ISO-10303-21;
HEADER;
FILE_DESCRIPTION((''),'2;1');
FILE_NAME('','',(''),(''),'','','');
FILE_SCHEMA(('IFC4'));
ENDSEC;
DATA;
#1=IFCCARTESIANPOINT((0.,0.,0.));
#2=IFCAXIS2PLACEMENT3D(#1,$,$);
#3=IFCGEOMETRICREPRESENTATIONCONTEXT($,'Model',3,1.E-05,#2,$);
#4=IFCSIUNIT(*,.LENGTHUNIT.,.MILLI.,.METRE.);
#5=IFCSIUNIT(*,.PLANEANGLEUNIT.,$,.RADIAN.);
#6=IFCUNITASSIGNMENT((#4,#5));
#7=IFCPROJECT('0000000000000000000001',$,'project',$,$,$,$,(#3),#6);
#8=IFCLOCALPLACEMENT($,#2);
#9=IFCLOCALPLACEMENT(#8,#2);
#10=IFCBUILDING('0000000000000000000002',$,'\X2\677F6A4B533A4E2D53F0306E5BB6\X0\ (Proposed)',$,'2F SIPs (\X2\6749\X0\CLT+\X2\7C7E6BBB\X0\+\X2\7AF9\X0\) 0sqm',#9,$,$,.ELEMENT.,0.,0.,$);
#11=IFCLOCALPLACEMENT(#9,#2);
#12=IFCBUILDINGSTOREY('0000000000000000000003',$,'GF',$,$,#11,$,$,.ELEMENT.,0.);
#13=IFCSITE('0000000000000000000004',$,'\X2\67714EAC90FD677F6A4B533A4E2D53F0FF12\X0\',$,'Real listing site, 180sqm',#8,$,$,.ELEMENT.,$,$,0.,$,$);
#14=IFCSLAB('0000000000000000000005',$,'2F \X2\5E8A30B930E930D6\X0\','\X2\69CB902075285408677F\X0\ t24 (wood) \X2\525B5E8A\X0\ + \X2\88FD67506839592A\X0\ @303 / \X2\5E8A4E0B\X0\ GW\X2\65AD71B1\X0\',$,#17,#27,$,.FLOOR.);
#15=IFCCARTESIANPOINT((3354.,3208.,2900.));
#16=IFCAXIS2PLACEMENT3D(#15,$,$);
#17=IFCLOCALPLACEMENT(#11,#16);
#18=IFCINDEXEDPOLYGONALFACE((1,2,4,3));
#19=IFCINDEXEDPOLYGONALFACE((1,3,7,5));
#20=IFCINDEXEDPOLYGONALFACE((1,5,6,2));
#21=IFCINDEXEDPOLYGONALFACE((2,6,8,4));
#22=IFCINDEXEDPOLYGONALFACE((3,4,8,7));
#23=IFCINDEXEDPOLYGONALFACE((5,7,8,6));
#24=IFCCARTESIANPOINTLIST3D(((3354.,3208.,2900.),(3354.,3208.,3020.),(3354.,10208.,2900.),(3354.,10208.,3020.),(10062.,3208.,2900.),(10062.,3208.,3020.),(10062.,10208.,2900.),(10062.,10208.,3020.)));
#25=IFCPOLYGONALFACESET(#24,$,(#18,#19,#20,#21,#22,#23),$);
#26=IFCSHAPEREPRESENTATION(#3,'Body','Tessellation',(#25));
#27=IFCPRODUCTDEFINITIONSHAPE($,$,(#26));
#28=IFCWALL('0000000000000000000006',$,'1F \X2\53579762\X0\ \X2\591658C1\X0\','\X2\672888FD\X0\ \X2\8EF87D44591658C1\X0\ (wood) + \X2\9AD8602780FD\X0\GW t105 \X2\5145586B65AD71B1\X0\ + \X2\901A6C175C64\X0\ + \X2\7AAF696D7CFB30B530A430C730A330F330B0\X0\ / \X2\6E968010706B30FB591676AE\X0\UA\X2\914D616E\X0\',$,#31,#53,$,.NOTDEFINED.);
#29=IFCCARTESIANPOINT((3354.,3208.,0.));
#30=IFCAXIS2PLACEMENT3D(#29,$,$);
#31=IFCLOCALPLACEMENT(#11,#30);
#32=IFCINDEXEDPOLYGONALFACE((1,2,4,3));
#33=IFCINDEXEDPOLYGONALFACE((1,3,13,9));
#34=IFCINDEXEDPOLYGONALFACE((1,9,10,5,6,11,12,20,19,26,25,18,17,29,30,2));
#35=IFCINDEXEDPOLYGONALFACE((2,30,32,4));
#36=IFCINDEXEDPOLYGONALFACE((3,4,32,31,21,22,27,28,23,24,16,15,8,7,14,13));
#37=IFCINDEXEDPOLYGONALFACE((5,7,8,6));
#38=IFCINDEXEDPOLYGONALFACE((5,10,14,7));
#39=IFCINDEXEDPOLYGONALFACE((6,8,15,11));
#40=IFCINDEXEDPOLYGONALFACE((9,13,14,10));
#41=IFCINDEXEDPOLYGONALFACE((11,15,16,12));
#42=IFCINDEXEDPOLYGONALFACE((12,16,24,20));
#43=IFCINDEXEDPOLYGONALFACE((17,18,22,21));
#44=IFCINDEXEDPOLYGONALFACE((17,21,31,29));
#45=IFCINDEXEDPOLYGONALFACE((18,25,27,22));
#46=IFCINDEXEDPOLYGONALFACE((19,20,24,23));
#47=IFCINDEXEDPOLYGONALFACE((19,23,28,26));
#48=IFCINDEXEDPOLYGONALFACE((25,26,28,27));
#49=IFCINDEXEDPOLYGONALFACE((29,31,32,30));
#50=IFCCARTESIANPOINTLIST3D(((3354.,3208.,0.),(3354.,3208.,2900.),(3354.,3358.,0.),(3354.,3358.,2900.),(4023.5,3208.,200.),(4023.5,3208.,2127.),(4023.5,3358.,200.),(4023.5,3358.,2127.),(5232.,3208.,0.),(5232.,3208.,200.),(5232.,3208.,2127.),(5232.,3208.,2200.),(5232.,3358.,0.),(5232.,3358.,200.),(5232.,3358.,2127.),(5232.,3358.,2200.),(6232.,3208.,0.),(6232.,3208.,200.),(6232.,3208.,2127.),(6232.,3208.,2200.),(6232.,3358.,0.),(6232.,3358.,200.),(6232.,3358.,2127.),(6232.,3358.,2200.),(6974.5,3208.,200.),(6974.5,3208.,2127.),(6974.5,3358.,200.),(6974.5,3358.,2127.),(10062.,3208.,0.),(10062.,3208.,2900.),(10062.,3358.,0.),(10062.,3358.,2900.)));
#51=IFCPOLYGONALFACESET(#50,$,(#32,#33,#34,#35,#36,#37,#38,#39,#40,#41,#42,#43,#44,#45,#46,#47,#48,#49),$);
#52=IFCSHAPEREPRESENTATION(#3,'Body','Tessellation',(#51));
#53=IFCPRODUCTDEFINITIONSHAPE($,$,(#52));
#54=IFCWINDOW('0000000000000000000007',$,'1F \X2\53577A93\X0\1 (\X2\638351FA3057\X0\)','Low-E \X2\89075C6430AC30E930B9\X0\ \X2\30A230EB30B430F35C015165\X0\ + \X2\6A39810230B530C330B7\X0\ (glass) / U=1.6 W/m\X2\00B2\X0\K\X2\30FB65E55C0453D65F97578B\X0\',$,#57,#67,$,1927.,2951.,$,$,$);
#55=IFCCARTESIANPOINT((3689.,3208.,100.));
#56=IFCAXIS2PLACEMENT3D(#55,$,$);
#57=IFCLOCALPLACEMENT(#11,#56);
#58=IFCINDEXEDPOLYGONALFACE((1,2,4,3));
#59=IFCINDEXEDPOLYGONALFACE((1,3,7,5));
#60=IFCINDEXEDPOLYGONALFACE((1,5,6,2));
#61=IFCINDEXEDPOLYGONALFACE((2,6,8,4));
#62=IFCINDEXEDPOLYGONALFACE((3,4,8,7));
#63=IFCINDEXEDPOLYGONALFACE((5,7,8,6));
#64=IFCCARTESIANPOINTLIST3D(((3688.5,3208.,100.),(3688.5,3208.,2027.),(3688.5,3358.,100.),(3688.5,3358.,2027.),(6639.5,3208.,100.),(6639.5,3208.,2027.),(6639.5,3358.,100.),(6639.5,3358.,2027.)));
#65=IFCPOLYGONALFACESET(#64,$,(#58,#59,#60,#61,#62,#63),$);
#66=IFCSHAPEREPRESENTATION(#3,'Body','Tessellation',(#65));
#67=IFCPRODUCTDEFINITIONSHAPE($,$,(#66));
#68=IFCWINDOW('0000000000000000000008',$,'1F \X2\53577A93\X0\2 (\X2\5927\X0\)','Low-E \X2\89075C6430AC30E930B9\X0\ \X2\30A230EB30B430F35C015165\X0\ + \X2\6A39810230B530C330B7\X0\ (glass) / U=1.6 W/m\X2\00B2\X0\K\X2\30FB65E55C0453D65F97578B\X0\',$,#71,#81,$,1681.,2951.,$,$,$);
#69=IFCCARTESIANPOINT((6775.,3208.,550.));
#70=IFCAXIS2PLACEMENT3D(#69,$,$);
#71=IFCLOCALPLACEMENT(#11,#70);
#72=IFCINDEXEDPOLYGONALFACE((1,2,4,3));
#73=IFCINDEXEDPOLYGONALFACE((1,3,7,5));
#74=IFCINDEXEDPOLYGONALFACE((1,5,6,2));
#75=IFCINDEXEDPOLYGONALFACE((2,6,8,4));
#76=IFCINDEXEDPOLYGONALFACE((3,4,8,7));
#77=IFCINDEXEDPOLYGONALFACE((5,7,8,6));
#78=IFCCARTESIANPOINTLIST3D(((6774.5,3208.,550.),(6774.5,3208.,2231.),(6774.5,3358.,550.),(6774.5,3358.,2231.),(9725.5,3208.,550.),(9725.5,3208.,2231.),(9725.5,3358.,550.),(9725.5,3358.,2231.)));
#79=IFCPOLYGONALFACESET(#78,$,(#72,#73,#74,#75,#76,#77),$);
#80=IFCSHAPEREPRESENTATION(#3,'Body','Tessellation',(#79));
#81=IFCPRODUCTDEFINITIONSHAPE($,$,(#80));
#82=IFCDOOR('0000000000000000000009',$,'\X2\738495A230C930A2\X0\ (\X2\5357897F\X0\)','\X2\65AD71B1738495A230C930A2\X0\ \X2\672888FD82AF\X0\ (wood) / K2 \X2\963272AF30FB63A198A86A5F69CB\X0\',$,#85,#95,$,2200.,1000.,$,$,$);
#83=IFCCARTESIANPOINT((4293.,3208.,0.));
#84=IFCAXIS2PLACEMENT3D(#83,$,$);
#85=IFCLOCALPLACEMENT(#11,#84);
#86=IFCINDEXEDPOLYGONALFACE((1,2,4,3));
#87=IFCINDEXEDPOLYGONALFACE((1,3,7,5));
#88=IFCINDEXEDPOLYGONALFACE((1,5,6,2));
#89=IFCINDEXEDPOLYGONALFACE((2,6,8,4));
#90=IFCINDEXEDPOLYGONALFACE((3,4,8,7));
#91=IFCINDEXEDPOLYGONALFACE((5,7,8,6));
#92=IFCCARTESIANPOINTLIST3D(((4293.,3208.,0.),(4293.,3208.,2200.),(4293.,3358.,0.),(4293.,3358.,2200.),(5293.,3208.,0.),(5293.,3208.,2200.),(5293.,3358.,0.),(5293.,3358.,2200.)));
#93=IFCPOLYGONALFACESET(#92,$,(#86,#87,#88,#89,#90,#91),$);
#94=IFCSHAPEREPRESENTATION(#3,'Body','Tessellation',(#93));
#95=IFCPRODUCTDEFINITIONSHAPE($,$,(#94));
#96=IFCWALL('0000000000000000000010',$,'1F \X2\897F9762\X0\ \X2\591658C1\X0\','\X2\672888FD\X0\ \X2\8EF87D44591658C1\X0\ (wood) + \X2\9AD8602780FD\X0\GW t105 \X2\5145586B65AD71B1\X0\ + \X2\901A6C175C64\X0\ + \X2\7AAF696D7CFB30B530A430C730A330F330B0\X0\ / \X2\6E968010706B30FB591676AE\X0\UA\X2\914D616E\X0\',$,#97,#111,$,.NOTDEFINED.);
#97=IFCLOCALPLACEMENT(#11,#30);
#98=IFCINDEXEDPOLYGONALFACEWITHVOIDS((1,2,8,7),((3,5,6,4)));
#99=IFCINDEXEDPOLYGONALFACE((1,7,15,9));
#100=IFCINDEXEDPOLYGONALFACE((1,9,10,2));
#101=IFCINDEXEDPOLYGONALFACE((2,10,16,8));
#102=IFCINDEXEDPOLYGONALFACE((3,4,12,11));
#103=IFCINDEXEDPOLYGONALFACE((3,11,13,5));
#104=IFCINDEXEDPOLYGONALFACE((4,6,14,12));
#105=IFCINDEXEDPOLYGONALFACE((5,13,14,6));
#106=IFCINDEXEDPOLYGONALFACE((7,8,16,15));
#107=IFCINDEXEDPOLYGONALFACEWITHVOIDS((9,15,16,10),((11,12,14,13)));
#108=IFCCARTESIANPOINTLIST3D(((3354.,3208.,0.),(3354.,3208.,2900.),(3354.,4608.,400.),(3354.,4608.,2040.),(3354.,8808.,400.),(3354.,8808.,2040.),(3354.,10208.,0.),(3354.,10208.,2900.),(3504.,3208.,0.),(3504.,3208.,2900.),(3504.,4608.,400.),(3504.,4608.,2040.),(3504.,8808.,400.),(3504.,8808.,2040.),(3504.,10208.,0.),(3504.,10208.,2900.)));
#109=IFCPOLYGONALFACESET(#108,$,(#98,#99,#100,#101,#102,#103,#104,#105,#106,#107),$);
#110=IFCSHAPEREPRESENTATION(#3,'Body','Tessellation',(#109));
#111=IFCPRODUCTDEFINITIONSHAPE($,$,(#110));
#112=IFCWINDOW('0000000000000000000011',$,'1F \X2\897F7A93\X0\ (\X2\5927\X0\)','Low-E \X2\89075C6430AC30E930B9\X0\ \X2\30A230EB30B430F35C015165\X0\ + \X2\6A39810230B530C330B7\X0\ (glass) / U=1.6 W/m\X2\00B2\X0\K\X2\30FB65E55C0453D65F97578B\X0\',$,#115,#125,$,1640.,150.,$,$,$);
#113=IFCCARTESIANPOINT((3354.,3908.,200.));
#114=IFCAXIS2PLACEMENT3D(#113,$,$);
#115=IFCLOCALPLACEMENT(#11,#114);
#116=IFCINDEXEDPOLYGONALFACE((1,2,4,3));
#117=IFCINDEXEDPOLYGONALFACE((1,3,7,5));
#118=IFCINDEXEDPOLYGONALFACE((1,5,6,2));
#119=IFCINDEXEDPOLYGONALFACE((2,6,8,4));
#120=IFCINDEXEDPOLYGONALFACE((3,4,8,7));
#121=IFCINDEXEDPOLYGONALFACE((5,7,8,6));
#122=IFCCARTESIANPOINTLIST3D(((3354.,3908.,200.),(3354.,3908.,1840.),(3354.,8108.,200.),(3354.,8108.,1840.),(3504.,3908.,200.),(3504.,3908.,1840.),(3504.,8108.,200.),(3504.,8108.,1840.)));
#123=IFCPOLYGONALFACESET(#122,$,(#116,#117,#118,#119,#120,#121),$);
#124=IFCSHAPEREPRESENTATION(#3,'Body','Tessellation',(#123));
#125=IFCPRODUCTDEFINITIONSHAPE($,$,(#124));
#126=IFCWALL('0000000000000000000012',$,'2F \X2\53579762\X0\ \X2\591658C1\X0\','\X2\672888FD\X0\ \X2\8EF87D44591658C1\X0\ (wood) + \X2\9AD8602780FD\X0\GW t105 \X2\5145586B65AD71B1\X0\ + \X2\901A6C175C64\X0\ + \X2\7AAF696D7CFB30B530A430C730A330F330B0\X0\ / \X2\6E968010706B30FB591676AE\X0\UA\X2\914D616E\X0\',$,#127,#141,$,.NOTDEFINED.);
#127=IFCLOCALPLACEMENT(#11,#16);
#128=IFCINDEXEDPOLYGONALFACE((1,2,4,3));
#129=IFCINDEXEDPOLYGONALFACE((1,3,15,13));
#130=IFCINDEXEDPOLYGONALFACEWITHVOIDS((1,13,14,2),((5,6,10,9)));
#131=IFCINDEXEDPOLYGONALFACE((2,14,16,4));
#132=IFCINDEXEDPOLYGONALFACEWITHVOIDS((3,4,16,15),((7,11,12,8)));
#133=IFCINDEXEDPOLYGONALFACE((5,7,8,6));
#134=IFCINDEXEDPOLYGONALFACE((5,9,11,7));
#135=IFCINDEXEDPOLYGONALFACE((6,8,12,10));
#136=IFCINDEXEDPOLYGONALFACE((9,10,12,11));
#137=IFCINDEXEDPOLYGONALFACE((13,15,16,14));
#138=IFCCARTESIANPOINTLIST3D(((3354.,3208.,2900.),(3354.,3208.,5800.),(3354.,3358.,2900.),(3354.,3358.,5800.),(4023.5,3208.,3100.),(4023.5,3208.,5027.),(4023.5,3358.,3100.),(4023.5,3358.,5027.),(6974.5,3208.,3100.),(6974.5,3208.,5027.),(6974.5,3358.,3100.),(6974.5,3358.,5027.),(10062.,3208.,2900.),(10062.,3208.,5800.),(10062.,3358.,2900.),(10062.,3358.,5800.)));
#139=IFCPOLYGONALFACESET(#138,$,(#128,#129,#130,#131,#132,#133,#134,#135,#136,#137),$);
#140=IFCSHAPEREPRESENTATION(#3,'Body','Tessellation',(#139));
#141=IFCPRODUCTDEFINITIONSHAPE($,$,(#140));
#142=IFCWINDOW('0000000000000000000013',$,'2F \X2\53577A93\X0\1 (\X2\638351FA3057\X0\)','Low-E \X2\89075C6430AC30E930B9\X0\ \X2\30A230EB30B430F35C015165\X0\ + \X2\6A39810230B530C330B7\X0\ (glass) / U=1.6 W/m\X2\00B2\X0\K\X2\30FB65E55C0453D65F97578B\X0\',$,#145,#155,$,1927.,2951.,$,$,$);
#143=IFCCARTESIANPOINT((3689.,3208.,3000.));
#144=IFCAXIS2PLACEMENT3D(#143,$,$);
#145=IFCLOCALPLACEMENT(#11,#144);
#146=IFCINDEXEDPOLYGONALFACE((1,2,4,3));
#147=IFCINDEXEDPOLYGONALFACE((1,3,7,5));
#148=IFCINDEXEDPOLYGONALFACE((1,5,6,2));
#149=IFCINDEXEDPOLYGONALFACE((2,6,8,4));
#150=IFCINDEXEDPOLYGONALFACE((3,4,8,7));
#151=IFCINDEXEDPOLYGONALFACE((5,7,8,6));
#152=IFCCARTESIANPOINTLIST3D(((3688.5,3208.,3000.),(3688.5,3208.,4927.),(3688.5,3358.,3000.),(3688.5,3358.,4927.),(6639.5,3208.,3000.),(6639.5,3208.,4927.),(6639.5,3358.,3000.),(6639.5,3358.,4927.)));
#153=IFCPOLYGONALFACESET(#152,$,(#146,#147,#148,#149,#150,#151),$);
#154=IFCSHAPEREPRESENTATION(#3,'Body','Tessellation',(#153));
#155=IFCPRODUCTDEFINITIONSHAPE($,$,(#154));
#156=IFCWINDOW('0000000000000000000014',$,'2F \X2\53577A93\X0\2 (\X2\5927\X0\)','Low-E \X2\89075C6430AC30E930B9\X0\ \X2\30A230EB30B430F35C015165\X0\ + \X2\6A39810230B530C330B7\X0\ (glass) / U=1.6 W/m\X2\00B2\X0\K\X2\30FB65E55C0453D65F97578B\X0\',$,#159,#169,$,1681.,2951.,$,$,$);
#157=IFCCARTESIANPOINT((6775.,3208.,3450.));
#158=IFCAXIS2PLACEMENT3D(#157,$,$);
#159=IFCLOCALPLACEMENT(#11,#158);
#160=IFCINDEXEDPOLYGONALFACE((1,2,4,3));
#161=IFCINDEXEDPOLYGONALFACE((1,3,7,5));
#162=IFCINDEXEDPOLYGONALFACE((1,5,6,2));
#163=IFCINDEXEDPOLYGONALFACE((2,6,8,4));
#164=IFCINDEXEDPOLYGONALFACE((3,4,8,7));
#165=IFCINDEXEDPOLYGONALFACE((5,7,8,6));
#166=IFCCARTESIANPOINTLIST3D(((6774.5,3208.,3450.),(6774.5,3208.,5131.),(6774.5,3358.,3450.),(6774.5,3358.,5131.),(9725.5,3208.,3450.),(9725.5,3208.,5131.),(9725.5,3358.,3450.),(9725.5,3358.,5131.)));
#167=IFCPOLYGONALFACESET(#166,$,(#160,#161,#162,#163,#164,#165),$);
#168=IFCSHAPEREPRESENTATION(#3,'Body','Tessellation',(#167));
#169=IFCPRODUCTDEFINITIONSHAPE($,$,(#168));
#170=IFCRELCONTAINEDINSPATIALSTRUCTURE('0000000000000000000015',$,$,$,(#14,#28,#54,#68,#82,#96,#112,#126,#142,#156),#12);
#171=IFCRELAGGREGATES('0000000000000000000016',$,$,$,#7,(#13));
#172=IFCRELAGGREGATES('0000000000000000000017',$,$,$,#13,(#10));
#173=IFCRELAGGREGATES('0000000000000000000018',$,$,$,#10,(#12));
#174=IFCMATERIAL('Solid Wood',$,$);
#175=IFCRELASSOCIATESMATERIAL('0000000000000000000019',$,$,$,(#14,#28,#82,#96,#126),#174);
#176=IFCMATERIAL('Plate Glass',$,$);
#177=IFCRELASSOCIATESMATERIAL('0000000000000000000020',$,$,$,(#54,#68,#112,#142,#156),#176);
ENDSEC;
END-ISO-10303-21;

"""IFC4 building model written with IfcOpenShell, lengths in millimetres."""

from ifc_helpers import new_model, si_unit, frame, frame_2d, origin, place, context, project, spatial, rectangle, extrude, material, element, fill, save


model = new_model("IFC4")

# Units and contexts
model_context = context("Model", 3, precision=1e-05, world=origin())
ifc_project = project(units=[si_unit("LENGTHUNIT", "METRE", prefix="MILLI"), si_unit("PLANEANGLEUNIT", "RADIAN")], contexts=[model_context])

# Site, building, storey
site_placement = place(None, origin())
site = spatial("IfcSite", under=ifc_project, at=site_placement, Name="東京都板橋区中台２", ObjectType="Real listing site, 180sqm", CompositionType="ELEMENT", RefElevation=0.0)
building_placement = place(site_placement, origin())
building = spatial("IfcBuilding", under=site, at=building_placement, Name="板橋区中台の家 (Proposed)", ObjectType="2F SIPs (杉CLT+籾殻+竹) 0sqm", CompositionType="ELEMENT", ElevationOfRefHeight=0.0, ElevationOfTerrain=0.0)
storey_placement = place(building_placement, origin())
storey = spatial("IfcBuildingStorey", under=building, at=storey_placement, Name="GF", CompositionType="ELEMENT", Elevation=0.0)

# Slab
ifc_material_1 = material(Name="Solid Wood")
slab_1_placement = place(storey_placement, frame((3354.0, 3208.0, 2900.0)))
element("IfcSlab", 1, at=slab_1_placement, inside=storey, material=ifc_material_1, Name="2F 床スラブ", Description="構造用合板 t24 (wood) 剛床 + 製材根太 @303 / 床下 GW断熱", PredefinedType="FLOOR", context=model_context, shape_type="SweptSolid", body=[
    extrude(rectangle(XDim=6708.0, YDim=7000.0, at=frame_2d((3354.0, 3500.0))), frame((3354.0, 3208.0, 2900.0)), (0.0, 0.0, 1.0), 120.0),
])

# Wall, openings, windows, door
wall_1_placement = place(storey_placement, frame((3354.0, 3208.0, 0.0)))
wall_1 = element("IfcWall", 2, at=wall_1_placement, inside=storey, material=ifc_material_1, Name="1F 南面 外壁", Description="木製 軸組外壁 (wood) + 高性能GW t105 充填断熱 + 通気層 + 窯業系サイディング / 準耐火・外皮UA配慮", PredefinedType="NOTDEFINED", context=model_context, shape_type="SweptSolid", body=[
    extrude(rectangle(XDim=6708.0, YDim=150.0, at=frame_2d((3354.0, 75.0))), frame((3354.0, 3208.0, 0.0)), (0.0, 0.0, 1.0), 2900.0),
])
opening_1_placement = place(storey_placement, frame((3689.0, 3208.0, 100.0)))
opening_1 = element("IfcOpeningElement", 3, at=opening_1_placement, cuts=wall_1, PredefinedType="NOTDEFINED", context=model_context, shape_type="SweptSolid", body=[
    extrude(rectangle(XDim=2951.0, YDim=150.0, at=frame_2d((1475.0, 75.0))), frame((3689.0, 3208.0, 100.0)), (0.0, 0.0, 1.0), 1927.0),
])
opening_2_placement = place(storey_placement, frame((6775.0, 3208.0, 550.0)))
opening_2 = element("IfcOpeningElement", 4, at=opening_2_placement, cuts=wall_1, PredefinedType="NOTDEFINED", context=model_context, shape_type="SweptSolid", body=[
    extrude(rectangle(XDim=2951.0, YDim=150.0, at=frame_2d((1475.0, 75.0))), frame((6775.0, 3208.0, 550.0)), (0.0, 0.0, 1.0), 1681.0),
])
opening_3_placement = place(storey_placement, frame((4293.0, 3208.0, 0.0)))
opening_3 = element("IfcOpeningElement", 5, at=opening_3_placement, cuts=wall_1, PredefinedType="NOTDEFINED", context=model_context, shape_type="SweptSolid", body=[
    extrude(rectangle(XDim=1000.0, YDim=150.0, at=frame_2d((500.0, 75.0))), frame((4293.0, 3208.0, 0.0)), (0.0, 0.0, 1.0), 2200.0),
])
ifc_material_2 = material(Name="Plate Glass")
window_1_placement = place(storey_placement, frame((3689.0, 3208.0, 100.0)))
window_1 = element("IfcWindow", 6, at=window_1_placement, inside=storey, material=ifc_material_2, Name="1F 南窓1 (掃出し)", Description="Low-E 複層ガラス アルゴン封入 + 樹脂サッシ (glass) / U=1.6 W/m²K・日射取得型", OverallHeight=1927.0, OverallWidth=2951.0, context=model_context, shape_type="SweptSolid", body=[
    extrude(rectangle(XDim=2951.0, YDim=150.0, at=frame_2d((1475.0, 75.0))), frame((3689.0, 3208.0, 100.0)), (0.0, 0.0, 1.0), 1927.0),
])
fill(opening_1, window_1)
window_2_placement = place(storey_placement, frame((6775.0, 3208.0, 550.0)))
window_2 = element("IfcWindow", 7, at=window_2_placement, inside=storey, material=ifc_material_2, Name="1F 南窓2 (大)", Description="Low-E 複層ガラス アルゴン封入 + 樹脂サッシ (glass) / U=1.6 W/m²K・日射取得型", OverallHeight=1681.0, OverallWidth=2951.0, context=model_context, shape_type="SweptSolid", body=[
    extrude(rectangle(XDim=2951.0, YDim=150.0, at=frame_2d((1475.0, 75.0))), frame((6775.0, 3208.0, 550.0)), (0.0, 0.0, 1.0), 1681.0),
])
fill(opening_2, window_2)
door_placement = place(storey_placement, frame((4293.0, 3208.0, 0.0)))
door = element("IfcDoor", 8, at=door_placement, inside=storey, material=ifc_material_1, Name="玄関ドア (南西)", Description="断熱玄関ドア 木製芯 (wood) / K2 防犯・採風機構", OverallHeight=2200.0, OverallWidth=1000.0, context=model_context, shape_type="SweptSolid", body=[
    extrude(rectangle(XDim=1000.0, YDim=150.0, at=frame_2d((500.0, 75.0))), frame((4293.0, 3208.0, 0.0)), (0.0, 0.0, 1.0), 2200.0),
])
fill(opening_3, door)

# Wall, opening, window
wall_2_placement = place(storey_placement, frame((3354.0, 3208.0, 0.0)))
wall_2 = element("IfcWall", 9, at=wall_2_placement, inside=storey, material=ifc_material_1, Name="1F 西面 外壁", Description="木製 軸組外壁 (wood) + 高性能GW t105 充填断熱 + 通気層 + 窯業系サイディング / 準耐火・外皮UA配慮", PredefinedType="NOTDEFINED", context=model_context, shape_type="SweptSolid", body=[
    extrude(rectangle(XDim=150.0, YDim=7000.0, at=frame_2d((75.0, 3500.0))), frame((3354.0, 3208.0, 0.0)), (0.0, 0.0, 1.0), 2900.0),
])
opening_4_placement = place(storey_placement, frame((3354.0, 3908.0, 200.0)))
opening_4 = element("IfcOpeningElement", 10, at=opening_4_placement, cuts=wall_2, PredefinedType="NOTDEFINED", context=model_context, shape_type="SweptSolid", body=[
    extrude(rectangle(XDim=150.0, YDim=4200.0, at=frame_2d((75.0, 2100.0))), frame((3354.0, 3908.0, 200.0)), (0.0, 0.0, 1.0), 1640.0),
])
window_3_placement = place(storey_placement, frame((3354.0, 3908.0, 200.0)))
window_3 = element("IfcWindow", 11, at=window_3_placement, inside=storey, material=ifc_material_2, Name="1F 西窓 (大)", Description="Low-E 複層ガラス アルゴン封入 + 樹脂サッシ (glass) / U=1.6 W/m²K・日射取得型", OverallHeight=1640.0, OverallWidth=150.0, context=model_context, shape_type="SweptSolid", body=[
    extrude(rectangle(XDim=150.0, YDim=4200.0, at=frame_2d((75.0, 2100.0))), frame((3354.0, 3908.0, 200.0)), (0.0, 0.0, 1.0), 1640.0),
])
fill(opening_4, window_3)

# Wall, openings, windows
wall_3_placement = place(storey_placement, frame((3354.0, 3208.0, 2900.0)))
wall_3 = element("IfcWall", 12, at=wall_3_placement, inside=storey, material=ifc_material_1, Name="2F 南面 外壁", Description="木製 軸組外壁 (wood) + 高性能GW t105 充填断熱 + 通気層 + 窯業系サイディング / 準耐火・外皮UA配慮", PredefinedType="NOTDEFINED", context=model_context, shape_type="SweptSolid", body=[
    extrude(rectangle(XDim=6708.0, YDim=150.0, at=frame_2d((3354.0, 75.0))), frame((3354.0, 3208.0, 2900.0)), (0.0, 0.0, 1.0), 2900.0),
])
opening_5_placement = place(storey_placement, frame((3689.0, 3208.0, 3000.0)))
opening_5 = element("IfcOpeningElement", 13, at=opening_5_placement, cuts=wall_3, PredefinedType="NOTDEFINED", context=model_context, shape_type="SweptSolid", body=[
    extrude(rectangle(XDim=2951.0, YDim=150.0, at=frame_2d((1475.0, 75.0))), frame((3689.0, 3208.0, 3000.0)), (0.0, 0.0, 1.0), 1927.0),
])
opening_6_placement = place(storey_placement, frame((6775.0, 3208.0, 3450.0)))
opening_6 = element("IfcOpeningElement", 14, at=opening_6_placement, cuts=wall_3, PredefinedType="NOTDEFINED", context=model_context, shape_type="SweptSolid", body=[
    extrude(rectangle(XDim=2951.0, YDim=150.0, at=frame_2d((1475.0, 75.0))), frame((6775.0, 3208.0, 3450.0)), (0.0, 0.0, 1.0), 1681.0),
])
window_4_placement = place(storey_placement, frame((3689.0, 3208.0, 3000.0)))
window_4 = element("IfcWindow", 15, at=window_4_placement, inside=storey, material=ifc_material_2, Name="2F 南窓1 (掃出し)", Description="Low-E 複層ガラス アルゴン封入 + 樹脂サッシ (glass) / U=1.6 W/m²K・日射取得型", OverallHeight=1927.0, OverallWidth=2951.0, context=model_context, shape_type="SweptSolid", body=[
    extrude(rectangle(XDim=2951.0, YDim=150.0, at=frame_2d((1475.0, 75.0))), frame((3689.0, 3208.0, 3000.0)), (0.0, 0.0, 1.0), 1927.0),
])
fill(opening_5, window_4)
window_5_placement = place(storey_placement, frame((6775.0, 3208.0, 3450.0)))
window_5 = element("IfcWindow", 16, at=window_5_placement, inside=storey, material=ifc_material_2, Name="2F 南窓2 (大)", Description="Low-E 複層ガラス アルゴン封入 + 樹脂サッシ (glass) / U=1.6 W/m²K・日射取得型", OverallHeight=1681.0, OverallWidth=2951.0, context=model_context, shape_type="SweptSolid", body=[
    extrude(rectangle(XDim=2951.0, YDim=150.0, at=frame_2d((1475.0, 75.0))), frame((6775.0, 3208.0, 3450.0)), (0.0, 0.0, 1.0), 1681.0),
])
fill(opening_6, window_5)

save(model, "model.ifc")
